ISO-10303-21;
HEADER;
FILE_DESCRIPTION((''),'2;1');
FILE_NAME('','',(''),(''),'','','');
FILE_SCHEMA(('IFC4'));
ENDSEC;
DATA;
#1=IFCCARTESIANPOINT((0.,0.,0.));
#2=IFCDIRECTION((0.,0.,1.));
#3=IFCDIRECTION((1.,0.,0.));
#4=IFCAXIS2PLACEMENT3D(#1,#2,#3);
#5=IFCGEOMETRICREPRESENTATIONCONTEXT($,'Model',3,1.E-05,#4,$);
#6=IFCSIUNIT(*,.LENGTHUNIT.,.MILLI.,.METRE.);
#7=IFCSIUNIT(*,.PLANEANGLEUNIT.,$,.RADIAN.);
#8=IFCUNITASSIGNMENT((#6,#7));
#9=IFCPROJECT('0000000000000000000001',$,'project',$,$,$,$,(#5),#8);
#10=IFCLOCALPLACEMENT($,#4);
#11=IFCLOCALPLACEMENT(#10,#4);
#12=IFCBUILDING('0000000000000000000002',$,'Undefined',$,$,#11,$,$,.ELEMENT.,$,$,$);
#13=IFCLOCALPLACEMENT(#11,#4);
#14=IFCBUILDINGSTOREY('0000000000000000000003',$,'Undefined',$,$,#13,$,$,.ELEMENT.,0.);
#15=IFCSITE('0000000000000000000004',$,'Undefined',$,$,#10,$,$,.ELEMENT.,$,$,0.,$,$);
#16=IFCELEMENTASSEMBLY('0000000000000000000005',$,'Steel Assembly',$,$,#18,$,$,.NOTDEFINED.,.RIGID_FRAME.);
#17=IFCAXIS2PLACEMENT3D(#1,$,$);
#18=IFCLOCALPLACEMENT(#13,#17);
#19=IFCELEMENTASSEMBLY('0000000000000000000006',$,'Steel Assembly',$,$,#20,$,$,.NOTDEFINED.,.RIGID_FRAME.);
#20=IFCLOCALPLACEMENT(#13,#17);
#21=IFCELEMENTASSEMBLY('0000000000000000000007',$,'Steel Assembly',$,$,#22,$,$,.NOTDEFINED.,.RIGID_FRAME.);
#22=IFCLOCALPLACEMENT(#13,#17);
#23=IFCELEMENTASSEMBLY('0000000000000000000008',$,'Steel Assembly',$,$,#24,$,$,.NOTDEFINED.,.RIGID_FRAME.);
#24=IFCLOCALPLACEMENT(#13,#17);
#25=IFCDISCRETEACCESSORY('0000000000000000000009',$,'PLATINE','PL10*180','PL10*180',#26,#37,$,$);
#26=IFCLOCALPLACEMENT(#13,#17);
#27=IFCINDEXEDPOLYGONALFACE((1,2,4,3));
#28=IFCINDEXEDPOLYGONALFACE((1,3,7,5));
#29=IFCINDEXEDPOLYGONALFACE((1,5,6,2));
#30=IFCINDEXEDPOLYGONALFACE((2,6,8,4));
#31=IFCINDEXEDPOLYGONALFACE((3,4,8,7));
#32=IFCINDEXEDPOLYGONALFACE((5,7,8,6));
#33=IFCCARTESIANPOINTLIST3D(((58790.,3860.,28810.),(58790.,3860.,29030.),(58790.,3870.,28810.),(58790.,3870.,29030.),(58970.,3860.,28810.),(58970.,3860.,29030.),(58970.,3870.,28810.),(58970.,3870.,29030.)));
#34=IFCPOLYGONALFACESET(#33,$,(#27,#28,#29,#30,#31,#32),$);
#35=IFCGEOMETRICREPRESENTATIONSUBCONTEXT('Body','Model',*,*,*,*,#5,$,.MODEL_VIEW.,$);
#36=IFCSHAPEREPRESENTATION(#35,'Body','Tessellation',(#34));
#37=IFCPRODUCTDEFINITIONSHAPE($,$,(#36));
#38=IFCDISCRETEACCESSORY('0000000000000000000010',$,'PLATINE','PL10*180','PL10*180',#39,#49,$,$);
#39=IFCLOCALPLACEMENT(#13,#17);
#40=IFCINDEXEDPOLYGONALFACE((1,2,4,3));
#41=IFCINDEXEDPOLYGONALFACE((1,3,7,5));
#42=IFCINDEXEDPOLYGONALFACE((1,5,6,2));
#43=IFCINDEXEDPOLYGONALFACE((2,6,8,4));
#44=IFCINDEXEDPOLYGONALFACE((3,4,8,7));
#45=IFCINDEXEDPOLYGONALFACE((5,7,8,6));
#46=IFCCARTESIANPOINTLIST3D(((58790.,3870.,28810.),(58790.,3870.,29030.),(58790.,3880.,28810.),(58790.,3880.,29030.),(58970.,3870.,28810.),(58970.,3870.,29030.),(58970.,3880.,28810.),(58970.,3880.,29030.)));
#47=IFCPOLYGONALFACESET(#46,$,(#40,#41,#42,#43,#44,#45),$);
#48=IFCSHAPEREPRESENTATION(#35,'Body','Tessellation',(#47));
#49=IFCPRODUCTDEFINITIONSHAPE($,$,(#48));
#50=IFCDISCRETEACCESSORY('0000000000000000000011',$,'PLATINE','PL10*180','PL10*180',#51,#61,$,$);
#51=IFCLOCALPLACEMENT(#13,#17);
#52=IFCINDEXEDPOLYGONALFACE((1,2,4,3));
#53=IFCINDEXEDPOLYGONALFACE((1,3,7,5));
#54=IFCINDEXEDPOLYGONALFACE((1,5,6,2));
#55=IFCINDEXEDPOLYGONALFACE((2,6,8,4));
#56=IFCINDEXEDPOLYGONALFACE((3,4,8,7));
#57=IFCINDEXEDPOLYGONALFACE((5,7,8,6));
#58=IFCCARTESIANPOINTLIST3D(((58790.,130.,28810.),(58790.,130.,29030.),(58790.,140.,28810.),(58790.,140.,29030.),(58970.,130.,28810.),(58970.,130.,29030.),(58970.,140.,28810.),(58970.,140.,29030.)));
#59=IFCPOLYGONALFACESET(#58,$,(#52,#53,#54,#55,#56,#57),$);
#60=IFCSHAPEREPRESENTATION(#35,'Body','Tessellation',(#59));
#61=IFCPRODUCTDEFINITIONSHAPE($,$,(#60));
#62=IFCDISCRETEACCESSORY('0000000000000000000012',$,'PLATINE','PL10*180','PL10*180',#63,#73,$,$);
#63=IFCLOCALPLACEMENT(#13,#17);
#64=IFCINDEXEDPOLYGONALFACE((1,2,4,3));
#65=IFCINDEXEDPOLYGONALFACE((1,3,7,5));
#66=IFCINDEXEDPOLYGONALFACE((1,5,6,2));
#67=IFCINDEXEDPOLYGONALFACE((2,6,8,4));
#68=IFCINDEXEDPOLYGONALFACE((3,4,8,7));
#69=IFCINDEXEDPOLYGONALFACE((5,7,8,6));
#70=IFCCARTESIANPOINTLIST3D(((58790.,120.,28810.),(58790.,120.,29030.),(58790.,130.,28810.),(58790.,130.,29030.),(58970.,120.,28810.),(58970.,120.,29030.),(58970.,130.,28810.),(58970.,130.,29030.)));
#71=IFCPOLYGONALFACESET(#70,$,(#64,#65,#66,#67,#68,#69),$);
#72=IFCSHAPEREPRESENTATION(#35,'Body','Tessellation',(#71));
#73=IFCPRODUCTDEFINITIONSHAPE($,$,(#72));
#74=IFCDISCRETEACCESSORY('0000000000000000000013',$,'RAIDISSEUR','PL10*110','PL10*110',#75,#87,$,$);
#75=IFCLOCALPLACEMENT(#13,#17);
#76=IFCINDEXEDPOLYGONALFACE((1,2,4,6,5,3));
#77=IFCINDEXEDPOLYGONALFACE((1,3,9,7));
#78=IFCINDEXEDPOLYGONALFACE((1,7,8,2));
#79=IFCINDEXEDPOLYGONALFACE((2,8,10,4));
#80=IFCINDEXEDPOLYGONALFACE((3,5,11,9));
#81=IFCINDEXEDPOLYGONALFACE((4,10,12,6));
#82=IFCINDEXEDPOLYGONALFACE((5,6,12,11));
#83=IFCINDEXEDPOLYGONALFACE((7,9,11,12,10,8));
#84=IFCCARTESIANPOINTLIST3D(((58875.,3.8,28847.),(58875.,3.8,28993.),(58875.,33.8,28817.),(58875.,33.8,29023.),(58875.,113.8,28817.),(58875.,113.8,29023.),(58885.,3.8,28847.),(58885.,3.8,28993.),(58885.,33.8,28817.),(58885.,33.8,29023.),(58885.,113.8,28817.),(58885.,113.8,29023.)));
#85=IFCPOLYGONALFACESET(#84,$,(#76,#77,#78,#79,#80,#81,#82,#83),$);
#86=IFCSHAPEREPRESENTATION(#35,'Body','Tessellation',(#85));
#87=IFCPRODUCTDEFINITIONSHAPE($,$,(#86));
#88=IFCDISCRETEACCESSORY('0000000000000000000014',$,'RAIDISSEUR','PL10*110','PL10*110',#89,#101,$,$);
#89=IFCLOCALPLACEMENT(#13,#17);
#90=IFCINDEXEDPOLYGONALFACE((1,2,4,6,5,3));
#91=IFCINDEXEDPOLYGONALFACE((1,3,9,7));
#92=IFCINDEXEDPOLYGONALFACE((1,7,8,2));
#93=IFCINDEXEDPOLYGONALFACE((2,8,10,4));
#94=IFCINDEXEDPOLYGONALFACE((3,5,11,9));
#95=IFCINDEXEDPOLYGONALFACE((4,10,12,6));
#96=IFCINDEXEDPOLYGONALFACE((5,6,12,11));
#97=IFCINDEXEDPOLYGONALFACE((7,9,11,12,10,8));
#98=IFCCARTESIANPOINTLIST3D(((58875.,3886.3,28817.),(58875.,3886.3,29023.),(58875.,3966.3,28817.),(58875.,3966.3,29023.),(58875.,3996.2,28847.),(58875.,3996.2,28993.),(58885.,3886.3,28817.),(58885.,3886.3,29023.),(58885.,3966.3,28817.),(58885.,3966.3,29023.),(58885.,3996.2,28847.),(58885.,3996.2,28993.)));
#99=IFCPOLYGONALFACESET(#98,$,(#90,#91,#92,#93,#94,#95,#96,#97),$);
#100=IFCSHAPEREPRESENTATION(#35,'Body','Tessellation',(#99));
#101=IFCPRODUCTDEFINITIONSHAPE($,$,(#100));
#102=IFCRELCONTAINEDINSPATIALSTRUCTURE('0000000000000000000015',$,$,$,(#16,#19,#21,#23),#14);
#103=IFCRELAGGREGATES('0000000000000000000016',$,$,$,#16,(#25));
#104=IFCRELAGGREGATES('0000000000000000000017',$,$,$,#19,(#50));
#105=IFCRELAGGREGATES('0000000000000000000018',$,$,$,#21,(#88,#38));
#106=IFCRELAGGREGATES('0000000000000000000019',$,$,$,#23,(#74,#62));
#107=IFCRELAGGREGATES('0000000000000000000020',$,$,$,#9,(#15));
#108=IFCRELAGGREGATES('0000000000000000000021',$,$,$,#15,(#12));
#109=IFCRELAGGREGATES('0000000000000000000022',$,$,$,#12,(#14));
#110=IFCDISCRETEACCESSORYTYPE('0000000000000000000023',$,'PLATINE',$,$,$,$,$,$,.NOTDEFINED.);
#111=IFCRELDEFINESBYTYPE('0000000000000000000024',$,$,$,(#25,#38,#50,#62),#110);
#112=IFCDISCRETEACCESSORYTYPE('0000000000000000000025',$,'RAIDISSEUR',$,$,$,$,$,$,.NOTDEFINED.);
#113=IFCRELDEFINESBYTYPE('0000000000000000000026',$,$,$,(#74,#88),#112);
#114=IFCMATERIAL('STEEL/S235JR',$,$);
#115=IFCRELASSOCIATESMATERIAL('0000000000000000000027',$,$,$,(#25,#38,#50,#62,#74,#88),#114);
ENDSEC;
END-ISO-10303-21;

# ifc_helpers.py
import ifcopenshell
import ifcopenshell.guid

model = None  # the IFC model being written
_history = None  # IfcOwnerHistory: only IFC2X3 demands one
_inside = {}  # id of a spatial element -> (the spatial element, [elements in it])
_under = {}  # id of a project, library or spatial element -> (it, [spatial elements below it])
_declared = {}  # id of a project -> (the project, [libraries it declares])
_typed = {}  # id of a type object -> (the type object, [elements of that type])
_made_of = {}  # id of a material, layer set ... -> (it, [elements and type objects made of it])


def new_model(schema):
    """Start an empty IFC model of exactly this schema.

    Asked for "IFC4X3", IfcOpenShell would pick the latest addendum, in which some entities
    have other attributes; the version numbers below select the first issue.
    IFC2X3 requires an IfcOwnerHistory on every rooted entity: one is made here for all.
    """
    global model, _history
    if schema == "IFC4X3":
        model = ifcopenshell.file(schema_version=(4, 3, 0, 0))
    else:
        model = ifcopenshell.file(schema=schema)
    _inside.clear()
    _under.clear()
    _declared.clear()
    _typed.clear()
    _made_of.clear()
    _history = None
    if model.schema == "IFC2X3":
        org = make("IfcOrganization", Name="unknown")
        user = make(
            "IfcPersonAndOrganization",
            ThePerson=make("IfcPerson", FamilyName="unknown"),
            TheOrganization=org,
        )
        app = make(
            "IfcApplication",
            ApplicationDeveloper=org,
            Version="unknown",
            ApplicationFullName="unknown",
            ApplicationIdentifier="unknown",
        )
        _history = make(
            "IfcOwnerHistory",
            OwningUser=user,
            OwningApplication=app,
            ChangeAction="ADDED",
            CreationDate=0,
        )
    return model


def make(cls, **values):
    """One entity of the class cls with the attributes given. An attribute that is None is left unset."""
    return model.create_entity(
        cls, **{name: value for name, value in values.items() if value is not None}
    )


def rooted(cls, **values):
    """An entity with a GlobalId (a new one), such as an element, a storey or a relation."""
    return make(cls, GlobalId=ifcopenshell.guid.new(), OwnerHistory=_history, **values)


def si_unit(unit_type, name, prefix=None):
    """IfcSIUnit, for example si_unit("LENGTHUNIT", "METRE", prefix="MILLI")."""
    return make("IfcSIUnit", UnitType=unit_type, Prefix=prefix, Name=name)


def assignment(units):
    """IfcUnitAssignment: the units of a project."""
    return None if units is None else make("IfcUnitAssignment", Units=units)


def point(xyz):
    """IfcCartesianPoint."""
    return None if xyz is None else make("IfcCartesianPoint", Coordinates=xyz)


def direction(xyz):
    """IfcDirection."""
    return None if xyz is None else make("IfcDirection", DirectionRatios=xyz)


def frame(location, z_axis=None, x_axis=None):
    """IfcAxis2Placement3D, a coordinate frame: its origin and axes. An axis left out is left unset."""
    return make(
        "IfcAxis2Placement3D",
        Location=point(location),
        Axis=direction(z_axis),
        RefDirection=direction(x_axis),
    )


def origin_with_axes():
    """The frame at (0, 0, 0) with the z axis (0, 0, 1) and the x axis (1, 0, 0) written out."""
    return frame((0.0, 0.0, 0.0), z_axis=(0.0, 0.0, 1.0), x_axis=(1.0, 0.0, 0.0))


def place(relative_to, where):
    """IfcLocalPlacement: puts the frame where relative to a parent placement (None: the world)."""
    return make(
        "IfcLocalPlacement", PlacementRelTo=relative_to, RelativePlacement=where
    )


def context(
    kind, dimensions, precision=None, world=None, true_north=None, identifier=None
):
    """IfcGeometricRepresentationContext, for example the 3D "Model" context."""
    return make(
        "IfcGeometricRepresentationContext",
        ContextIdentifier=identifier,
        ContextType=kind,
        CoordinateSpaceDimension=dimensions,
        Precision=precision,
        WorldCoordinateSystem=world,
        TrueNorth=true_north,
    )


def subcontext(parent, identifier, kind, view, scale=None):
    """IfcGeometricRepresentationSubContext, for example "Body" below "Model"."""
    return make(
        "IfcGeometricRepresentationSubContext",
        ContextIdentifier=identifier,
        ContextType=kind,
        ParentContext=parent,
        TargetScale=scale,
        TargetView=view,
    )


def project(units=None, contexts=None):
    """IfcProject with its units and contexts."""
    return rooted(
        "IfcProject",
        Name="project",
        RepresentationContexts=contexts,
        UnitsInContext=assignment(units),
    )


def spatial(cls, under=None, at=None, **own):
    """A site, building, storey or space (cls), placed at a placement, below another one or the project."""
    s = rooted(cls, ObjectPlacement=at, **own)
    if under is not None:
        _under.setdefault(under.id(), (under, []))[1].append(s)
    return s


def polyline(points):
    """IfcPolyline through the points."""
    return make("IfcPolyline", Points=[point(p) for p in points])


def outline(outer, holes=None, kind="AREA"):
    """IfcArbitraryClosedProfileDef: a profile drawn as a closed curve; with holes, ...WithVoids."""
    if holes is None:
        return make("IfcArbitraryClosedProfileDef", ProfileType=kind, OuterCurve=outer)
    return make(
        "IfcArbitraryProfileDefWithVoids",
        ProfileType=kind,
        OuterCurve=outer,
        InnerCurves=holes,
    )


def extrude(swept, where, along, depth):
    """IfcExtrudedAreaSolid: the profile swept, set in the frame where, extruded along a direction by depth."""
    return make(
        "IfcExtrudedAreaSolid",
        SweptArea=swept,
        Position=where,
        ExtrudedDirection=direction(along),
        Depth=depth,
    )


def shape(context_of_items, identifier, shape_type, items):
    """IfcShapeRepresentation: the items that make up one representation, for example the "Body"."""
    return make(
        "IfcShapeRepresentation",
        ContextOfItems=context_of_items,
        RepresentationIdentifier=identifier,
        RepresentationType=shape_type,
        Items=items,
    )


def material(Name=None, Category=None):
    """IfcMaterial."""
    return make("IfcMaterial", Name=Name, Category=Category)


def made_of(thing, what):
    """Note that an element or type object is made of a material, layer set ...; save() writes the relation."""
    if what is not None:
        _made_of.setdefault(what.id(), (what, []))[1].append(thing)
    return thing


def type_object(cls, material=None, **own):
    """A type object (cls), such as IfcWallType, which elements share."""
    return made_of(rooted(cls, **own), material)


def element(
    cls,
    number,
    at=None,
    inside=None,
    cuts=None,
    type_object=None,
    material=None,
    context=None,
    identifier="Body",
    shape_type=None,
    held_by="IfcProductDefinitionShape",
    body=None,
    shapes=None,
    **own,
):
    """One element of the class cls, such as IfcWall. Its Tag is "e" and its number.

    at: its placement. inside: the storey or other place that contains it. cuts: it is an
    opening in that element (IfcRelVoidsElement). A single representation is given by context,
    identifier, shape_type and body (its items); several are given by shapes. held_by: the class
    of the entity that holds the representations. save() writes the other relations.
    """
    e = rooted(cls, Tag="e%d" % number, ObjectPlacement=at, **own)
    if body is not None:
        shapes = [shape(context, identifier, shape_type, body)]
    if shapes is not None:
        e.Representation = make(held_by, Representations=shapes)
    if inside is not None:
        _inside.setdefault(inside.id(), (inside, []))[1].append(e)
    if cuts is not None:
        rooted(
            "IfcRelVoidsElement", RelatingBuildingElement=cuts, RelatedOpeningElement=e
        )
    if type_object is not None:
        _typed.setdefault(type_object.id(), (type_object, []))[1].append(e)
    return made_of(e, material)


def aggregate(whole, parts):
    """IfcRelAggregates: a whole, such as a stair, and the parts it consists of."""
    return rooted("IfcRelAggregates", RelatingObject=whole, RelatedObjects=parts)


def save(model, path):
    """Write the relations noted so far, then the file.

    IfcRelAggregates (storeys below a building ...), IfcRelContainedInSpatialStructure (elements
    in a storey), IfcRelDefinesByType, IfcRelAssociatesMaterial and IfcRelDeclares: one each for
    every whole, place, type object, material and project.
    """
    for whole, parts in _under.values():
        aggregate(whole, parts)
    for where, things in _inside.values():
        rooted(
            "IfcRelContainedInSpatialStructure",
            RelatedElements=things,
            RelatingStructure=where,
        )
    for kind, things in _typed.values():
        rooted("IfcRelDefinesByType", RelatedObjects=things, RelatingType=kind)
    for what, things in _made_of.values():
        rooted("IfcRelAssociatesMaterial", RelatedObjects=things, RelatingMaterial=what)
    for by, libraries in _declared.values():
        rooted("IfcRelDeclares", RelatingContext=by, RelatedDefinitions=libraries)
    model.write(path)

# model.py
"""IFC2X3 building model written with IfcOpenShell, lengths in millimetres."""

from ifc_helpers import new_model, si_unit, frame, origin_with_axes, place, context, subcontext, project, spatial, polyline, outline, extrude, material, type_object, element, aggregate, save


model = new_model("IFC2X3")

# Units and contexts
model_context = context("Model", 3, precision=1e-05, world=origin_with_axes())
body_context = subcontext(model_context, "Body", "Model", "MODEL_VIEW")
ifc_project = project(units=[si_unit("LENGTHUNIT", "METRE", prefix="MILLI"), si_unit("PLANEANGLEUNIT", "RADIAN")], contexts=[model_context])

# Site, building, storey
site_placement = place(None, origin_with_axes())
site = spatial("IfcSite", under=ifc_project, at=site_placement, Name="Undefined", CompositionType="ELEMENT", RefElevation=0.0)
building_placement = place(site_placement, origin_with_axes())
building = spatial("IfcBuilding", under=site, at=building_placement, Name="Undefined", CompositionType="ELEMENT")
storey_placement = place(building_placement, origin_with_axes())
storey = spatial("IfcBuildingStorey", under=building, at=storey_placement, Name="Undefined", CompositionType="ELEMENT", Elevation=0.0)

# Element assemblies
assembly_1_placement = place(storey_placement, origin_with_axes())
assembly_1 = element("IfcElementAssembly", 1, at=assembly_1_placement, inside=storey, Name="Steel Assembly", AssemblyPlace="NOTDEFINED", PredefinedType="RIGID_FRAME")
ifc_material_1 = material(Name="STEEL/S235JR")
assembly_2_placement = place(storey_placement, origin_with_axes())
assembly_2 = element("IfcElementAssembly", 2, at=assembly_2_placement, inside=storey, Name="Steel Assembly", AssemblyPlace="NOTDEFINED", PredefinedType="RIGID_FRAME")
assembly_3_placement = place(storey_placement, origin_with_axes())
assembly_3 = element("IfcElementAssembly", 3, at=assembly_3_placement, inside=storey, Name="Steel Assembly", AssemblyPlace="NOTDEFINED", PredefinedType="RIGID_FRAME")
assembly_4_placement = place(storey_placement, origin_with_axes())
assembly_4 = element("IfcElementAssembly", 4, at=assembly_4_placement, inside=storey, Name="Steel Assembly", AssemblyPlace="NOTDEFINED", PredefinedType="RIGID_FRAME")

# Discrete accessories
discrete_accessory_type_1 = type_object("IfcDiscreteAccessoryType", Name="PLATINE")
discrete_accessory_1_placement = place(assembly_1_placement, frame((58880.0, 3865.0, 28810.0), z_axis=(0.0, -1.0, 0.0), x_axis=(0.0, 0.0, 1.0)))
discrete_accessory_1 = element("IfcDiscreteAccessory", 5, at=discrete_accessory_1_placement, type_object=discrete_accessory_type_1, material=ifc_material_1, Name="PLATINE", Description="PL10*180", ObjectType="PL10*180", context=body_context, shape_type="SweptSolid", body=[
    extrude(outline(polyline([(220.0, 90.0), (220.0, -90.0), (0.0, -90.0), (0.0, 90.0), (220.0, 90.0)])), frame((0.0, 0.0, -5.0), z_axis=(0.0, 0.0, 1.0), x_axis=(1.0, 0.0, 0.0)), (0.0, 0.0, 1.0), 10.0),
])
aggregate(assembly_1, [discrete_accessory_1])
discrete_accessory_2_placement = place(assembly_3_placement, frame((58880.0, 3875.0, 28810.0), z_axis=(0.0, -1.0, 0.0), x_axis=(0.0, 0.0, 1.0)))
discrete_accessory_2 = element("IfcDiscreteAccessory", 6, at=discrete_accessory_2_placement, type_object=discrete_accessory_type_1, material=ifc_material_1, Name="PLATINE", Description="PL10*180", ObjectType="PL10*180", context=body_context, shape_type="SweptSolid", body=[
    extrude(outline(polyline([(220.0, 90.0), (220.0, -90.0), (0.0, -90.0), (0.0, 90.0), (220.0, 90.0)])), frame((0.0, 0.0, -5.0), z_axis=(0.0, 0.0, 1.0), x_axis=(1.0, 0.0, 0.0)), (0.0, 0.0, 1.0), 10.0),
])
discrete_accessory_3_placement = place(assembly_2_placement, frame((58880.0, 135.0, 28810.0), z_axis=(0.0, 1.0, 0.0), x_axis=(0.0, 0.0, 1.0)))
discrete_accessory_3 = element("IfcDiscreteAccessory", 7, at=discrete_accessory_3_placement, type_object=discrete_accessory_type_1, material=ifc_material_1, Name="PLATINE", Description="PL10*180", ObjectType="PL10*180", context=body_context, shape_type="SweptSolid", body=[
    extrude(outline(polyline([(0.0, 90.0), (220.0, 90.0), (220.0, -90.0), (0.0, -90.0), (0.0, 90.0)])), frame((0.0, 0.0, -5.0), z_axis=(0.0, 0.0, 1.0), x_axis=(1.0, 0.0, 0.0)), (0.0, 0.0, 1.0), 10.0),
])
aggregate(assembly_2, [discrete_accessory_3])
discrete_accessory_4_placement = place(assembly_4_placement, frame((58880.0, 125.0, 28810.0), z_axis=(0.0, 1.0, 0.0), x_axis=(0.0, 0.0, 1.0)))
discrete_accessory_4 = element("IfcDiscreteAccessory", 8, at=discrete_accessory_4_placement, type_object=discrete_accessory_type_1, material=ifc_material_1, Name="PLATINE", Description="PL10*180", ObjectType="PL10*180", context=body_context, shape_type="SweptSolid", body=[
    extrude(outline(polyline([(0.0, 90.0), (220.0, 90.0), (220.0, -90.0), (0.0, -90.0), (0.0, 90.0)])), frame((0.0, 0.0, -5.0), z_axis=(0.0, 0.0, 1.0), x_axis=(1.0, 0.0, 0.0)), (0.0, 0.0, 1.0), 10.0),
])
discrete_accessory_type_2 = type_object("IfcDiscreteAccessoryType", Name="RAIDISSEUR")
discrete_accessory_5_placement = place(assembly_4_placement, frame((58880.0, 3.8, 28817.0), z_axis=(1.0, 0.0, 0.0), x_axis=(0.0, 1.0, 0.0)))
discrete_accessory_5 = element("IfcDiscreteAccessory", 9, at=discrete_accessory_5_placement, type_object=discrete_accessory_type_2, material=ifc_material_1, Name="RAIDISSEUR", Description="PL10*110", ObjectType="PL10*110", context=body_context, shape_type="SweptSolid", body=[
    extrude(outline(polyline([(0.0, 30.0), (30.0, 0.0), (110.0, 0.0), (110.0, 206.0), (30.0, 206.0), (0.0, 176.0), (0.0, 30.0)])), frame((0.0, 0.0, -5.0), z_axis=(0.0, 0.0, 1.0), x_axis=(1.0, 0.0, 0.0)), (0.0, 0.0, 1.0), 10.0),
])
discrete_accessory_6_placement = place(assembly_3_placement, frame((58880.0, 3996.2, 28817.0), z_axis=(-1.0, 0.0, 0.0), x_axis=(0.0, -1.0, 0.0)))
discrete_accessory_6 = element("IfcDiscreteAccessory", 10, at=discrete_accessory_6_placement, type_object=discrete_accessory_type_2, material=ifc_material_1, Name="RAIDISSEUR", Description="PL10*110", ObjectType="PL10*110", context=body_context, shape_type="SweptSolid", body=[
    extrude(outline(polyline([(0.0, 30.0), (30.0, 0.0), (110.0, 0.0), (110.0, 206.0), (30.0, 206.0), (0.0, 176.0), (0.0, 30.0)])), frame((0.0, 0.0, -5.0), z_axis=(0.0, 0.0, 1.0), x_axis=(1.0, 0.0, 0.0)), (0.0, 0.0, 1.0), 10.0),
])
aggregate(assembly_3, [discrete_accessory_6, discrete_accessory_2])
aggregate(assembly_4, [discrete_accessory_5, discrete_accessory_4])

save(model, "model.ifc")
